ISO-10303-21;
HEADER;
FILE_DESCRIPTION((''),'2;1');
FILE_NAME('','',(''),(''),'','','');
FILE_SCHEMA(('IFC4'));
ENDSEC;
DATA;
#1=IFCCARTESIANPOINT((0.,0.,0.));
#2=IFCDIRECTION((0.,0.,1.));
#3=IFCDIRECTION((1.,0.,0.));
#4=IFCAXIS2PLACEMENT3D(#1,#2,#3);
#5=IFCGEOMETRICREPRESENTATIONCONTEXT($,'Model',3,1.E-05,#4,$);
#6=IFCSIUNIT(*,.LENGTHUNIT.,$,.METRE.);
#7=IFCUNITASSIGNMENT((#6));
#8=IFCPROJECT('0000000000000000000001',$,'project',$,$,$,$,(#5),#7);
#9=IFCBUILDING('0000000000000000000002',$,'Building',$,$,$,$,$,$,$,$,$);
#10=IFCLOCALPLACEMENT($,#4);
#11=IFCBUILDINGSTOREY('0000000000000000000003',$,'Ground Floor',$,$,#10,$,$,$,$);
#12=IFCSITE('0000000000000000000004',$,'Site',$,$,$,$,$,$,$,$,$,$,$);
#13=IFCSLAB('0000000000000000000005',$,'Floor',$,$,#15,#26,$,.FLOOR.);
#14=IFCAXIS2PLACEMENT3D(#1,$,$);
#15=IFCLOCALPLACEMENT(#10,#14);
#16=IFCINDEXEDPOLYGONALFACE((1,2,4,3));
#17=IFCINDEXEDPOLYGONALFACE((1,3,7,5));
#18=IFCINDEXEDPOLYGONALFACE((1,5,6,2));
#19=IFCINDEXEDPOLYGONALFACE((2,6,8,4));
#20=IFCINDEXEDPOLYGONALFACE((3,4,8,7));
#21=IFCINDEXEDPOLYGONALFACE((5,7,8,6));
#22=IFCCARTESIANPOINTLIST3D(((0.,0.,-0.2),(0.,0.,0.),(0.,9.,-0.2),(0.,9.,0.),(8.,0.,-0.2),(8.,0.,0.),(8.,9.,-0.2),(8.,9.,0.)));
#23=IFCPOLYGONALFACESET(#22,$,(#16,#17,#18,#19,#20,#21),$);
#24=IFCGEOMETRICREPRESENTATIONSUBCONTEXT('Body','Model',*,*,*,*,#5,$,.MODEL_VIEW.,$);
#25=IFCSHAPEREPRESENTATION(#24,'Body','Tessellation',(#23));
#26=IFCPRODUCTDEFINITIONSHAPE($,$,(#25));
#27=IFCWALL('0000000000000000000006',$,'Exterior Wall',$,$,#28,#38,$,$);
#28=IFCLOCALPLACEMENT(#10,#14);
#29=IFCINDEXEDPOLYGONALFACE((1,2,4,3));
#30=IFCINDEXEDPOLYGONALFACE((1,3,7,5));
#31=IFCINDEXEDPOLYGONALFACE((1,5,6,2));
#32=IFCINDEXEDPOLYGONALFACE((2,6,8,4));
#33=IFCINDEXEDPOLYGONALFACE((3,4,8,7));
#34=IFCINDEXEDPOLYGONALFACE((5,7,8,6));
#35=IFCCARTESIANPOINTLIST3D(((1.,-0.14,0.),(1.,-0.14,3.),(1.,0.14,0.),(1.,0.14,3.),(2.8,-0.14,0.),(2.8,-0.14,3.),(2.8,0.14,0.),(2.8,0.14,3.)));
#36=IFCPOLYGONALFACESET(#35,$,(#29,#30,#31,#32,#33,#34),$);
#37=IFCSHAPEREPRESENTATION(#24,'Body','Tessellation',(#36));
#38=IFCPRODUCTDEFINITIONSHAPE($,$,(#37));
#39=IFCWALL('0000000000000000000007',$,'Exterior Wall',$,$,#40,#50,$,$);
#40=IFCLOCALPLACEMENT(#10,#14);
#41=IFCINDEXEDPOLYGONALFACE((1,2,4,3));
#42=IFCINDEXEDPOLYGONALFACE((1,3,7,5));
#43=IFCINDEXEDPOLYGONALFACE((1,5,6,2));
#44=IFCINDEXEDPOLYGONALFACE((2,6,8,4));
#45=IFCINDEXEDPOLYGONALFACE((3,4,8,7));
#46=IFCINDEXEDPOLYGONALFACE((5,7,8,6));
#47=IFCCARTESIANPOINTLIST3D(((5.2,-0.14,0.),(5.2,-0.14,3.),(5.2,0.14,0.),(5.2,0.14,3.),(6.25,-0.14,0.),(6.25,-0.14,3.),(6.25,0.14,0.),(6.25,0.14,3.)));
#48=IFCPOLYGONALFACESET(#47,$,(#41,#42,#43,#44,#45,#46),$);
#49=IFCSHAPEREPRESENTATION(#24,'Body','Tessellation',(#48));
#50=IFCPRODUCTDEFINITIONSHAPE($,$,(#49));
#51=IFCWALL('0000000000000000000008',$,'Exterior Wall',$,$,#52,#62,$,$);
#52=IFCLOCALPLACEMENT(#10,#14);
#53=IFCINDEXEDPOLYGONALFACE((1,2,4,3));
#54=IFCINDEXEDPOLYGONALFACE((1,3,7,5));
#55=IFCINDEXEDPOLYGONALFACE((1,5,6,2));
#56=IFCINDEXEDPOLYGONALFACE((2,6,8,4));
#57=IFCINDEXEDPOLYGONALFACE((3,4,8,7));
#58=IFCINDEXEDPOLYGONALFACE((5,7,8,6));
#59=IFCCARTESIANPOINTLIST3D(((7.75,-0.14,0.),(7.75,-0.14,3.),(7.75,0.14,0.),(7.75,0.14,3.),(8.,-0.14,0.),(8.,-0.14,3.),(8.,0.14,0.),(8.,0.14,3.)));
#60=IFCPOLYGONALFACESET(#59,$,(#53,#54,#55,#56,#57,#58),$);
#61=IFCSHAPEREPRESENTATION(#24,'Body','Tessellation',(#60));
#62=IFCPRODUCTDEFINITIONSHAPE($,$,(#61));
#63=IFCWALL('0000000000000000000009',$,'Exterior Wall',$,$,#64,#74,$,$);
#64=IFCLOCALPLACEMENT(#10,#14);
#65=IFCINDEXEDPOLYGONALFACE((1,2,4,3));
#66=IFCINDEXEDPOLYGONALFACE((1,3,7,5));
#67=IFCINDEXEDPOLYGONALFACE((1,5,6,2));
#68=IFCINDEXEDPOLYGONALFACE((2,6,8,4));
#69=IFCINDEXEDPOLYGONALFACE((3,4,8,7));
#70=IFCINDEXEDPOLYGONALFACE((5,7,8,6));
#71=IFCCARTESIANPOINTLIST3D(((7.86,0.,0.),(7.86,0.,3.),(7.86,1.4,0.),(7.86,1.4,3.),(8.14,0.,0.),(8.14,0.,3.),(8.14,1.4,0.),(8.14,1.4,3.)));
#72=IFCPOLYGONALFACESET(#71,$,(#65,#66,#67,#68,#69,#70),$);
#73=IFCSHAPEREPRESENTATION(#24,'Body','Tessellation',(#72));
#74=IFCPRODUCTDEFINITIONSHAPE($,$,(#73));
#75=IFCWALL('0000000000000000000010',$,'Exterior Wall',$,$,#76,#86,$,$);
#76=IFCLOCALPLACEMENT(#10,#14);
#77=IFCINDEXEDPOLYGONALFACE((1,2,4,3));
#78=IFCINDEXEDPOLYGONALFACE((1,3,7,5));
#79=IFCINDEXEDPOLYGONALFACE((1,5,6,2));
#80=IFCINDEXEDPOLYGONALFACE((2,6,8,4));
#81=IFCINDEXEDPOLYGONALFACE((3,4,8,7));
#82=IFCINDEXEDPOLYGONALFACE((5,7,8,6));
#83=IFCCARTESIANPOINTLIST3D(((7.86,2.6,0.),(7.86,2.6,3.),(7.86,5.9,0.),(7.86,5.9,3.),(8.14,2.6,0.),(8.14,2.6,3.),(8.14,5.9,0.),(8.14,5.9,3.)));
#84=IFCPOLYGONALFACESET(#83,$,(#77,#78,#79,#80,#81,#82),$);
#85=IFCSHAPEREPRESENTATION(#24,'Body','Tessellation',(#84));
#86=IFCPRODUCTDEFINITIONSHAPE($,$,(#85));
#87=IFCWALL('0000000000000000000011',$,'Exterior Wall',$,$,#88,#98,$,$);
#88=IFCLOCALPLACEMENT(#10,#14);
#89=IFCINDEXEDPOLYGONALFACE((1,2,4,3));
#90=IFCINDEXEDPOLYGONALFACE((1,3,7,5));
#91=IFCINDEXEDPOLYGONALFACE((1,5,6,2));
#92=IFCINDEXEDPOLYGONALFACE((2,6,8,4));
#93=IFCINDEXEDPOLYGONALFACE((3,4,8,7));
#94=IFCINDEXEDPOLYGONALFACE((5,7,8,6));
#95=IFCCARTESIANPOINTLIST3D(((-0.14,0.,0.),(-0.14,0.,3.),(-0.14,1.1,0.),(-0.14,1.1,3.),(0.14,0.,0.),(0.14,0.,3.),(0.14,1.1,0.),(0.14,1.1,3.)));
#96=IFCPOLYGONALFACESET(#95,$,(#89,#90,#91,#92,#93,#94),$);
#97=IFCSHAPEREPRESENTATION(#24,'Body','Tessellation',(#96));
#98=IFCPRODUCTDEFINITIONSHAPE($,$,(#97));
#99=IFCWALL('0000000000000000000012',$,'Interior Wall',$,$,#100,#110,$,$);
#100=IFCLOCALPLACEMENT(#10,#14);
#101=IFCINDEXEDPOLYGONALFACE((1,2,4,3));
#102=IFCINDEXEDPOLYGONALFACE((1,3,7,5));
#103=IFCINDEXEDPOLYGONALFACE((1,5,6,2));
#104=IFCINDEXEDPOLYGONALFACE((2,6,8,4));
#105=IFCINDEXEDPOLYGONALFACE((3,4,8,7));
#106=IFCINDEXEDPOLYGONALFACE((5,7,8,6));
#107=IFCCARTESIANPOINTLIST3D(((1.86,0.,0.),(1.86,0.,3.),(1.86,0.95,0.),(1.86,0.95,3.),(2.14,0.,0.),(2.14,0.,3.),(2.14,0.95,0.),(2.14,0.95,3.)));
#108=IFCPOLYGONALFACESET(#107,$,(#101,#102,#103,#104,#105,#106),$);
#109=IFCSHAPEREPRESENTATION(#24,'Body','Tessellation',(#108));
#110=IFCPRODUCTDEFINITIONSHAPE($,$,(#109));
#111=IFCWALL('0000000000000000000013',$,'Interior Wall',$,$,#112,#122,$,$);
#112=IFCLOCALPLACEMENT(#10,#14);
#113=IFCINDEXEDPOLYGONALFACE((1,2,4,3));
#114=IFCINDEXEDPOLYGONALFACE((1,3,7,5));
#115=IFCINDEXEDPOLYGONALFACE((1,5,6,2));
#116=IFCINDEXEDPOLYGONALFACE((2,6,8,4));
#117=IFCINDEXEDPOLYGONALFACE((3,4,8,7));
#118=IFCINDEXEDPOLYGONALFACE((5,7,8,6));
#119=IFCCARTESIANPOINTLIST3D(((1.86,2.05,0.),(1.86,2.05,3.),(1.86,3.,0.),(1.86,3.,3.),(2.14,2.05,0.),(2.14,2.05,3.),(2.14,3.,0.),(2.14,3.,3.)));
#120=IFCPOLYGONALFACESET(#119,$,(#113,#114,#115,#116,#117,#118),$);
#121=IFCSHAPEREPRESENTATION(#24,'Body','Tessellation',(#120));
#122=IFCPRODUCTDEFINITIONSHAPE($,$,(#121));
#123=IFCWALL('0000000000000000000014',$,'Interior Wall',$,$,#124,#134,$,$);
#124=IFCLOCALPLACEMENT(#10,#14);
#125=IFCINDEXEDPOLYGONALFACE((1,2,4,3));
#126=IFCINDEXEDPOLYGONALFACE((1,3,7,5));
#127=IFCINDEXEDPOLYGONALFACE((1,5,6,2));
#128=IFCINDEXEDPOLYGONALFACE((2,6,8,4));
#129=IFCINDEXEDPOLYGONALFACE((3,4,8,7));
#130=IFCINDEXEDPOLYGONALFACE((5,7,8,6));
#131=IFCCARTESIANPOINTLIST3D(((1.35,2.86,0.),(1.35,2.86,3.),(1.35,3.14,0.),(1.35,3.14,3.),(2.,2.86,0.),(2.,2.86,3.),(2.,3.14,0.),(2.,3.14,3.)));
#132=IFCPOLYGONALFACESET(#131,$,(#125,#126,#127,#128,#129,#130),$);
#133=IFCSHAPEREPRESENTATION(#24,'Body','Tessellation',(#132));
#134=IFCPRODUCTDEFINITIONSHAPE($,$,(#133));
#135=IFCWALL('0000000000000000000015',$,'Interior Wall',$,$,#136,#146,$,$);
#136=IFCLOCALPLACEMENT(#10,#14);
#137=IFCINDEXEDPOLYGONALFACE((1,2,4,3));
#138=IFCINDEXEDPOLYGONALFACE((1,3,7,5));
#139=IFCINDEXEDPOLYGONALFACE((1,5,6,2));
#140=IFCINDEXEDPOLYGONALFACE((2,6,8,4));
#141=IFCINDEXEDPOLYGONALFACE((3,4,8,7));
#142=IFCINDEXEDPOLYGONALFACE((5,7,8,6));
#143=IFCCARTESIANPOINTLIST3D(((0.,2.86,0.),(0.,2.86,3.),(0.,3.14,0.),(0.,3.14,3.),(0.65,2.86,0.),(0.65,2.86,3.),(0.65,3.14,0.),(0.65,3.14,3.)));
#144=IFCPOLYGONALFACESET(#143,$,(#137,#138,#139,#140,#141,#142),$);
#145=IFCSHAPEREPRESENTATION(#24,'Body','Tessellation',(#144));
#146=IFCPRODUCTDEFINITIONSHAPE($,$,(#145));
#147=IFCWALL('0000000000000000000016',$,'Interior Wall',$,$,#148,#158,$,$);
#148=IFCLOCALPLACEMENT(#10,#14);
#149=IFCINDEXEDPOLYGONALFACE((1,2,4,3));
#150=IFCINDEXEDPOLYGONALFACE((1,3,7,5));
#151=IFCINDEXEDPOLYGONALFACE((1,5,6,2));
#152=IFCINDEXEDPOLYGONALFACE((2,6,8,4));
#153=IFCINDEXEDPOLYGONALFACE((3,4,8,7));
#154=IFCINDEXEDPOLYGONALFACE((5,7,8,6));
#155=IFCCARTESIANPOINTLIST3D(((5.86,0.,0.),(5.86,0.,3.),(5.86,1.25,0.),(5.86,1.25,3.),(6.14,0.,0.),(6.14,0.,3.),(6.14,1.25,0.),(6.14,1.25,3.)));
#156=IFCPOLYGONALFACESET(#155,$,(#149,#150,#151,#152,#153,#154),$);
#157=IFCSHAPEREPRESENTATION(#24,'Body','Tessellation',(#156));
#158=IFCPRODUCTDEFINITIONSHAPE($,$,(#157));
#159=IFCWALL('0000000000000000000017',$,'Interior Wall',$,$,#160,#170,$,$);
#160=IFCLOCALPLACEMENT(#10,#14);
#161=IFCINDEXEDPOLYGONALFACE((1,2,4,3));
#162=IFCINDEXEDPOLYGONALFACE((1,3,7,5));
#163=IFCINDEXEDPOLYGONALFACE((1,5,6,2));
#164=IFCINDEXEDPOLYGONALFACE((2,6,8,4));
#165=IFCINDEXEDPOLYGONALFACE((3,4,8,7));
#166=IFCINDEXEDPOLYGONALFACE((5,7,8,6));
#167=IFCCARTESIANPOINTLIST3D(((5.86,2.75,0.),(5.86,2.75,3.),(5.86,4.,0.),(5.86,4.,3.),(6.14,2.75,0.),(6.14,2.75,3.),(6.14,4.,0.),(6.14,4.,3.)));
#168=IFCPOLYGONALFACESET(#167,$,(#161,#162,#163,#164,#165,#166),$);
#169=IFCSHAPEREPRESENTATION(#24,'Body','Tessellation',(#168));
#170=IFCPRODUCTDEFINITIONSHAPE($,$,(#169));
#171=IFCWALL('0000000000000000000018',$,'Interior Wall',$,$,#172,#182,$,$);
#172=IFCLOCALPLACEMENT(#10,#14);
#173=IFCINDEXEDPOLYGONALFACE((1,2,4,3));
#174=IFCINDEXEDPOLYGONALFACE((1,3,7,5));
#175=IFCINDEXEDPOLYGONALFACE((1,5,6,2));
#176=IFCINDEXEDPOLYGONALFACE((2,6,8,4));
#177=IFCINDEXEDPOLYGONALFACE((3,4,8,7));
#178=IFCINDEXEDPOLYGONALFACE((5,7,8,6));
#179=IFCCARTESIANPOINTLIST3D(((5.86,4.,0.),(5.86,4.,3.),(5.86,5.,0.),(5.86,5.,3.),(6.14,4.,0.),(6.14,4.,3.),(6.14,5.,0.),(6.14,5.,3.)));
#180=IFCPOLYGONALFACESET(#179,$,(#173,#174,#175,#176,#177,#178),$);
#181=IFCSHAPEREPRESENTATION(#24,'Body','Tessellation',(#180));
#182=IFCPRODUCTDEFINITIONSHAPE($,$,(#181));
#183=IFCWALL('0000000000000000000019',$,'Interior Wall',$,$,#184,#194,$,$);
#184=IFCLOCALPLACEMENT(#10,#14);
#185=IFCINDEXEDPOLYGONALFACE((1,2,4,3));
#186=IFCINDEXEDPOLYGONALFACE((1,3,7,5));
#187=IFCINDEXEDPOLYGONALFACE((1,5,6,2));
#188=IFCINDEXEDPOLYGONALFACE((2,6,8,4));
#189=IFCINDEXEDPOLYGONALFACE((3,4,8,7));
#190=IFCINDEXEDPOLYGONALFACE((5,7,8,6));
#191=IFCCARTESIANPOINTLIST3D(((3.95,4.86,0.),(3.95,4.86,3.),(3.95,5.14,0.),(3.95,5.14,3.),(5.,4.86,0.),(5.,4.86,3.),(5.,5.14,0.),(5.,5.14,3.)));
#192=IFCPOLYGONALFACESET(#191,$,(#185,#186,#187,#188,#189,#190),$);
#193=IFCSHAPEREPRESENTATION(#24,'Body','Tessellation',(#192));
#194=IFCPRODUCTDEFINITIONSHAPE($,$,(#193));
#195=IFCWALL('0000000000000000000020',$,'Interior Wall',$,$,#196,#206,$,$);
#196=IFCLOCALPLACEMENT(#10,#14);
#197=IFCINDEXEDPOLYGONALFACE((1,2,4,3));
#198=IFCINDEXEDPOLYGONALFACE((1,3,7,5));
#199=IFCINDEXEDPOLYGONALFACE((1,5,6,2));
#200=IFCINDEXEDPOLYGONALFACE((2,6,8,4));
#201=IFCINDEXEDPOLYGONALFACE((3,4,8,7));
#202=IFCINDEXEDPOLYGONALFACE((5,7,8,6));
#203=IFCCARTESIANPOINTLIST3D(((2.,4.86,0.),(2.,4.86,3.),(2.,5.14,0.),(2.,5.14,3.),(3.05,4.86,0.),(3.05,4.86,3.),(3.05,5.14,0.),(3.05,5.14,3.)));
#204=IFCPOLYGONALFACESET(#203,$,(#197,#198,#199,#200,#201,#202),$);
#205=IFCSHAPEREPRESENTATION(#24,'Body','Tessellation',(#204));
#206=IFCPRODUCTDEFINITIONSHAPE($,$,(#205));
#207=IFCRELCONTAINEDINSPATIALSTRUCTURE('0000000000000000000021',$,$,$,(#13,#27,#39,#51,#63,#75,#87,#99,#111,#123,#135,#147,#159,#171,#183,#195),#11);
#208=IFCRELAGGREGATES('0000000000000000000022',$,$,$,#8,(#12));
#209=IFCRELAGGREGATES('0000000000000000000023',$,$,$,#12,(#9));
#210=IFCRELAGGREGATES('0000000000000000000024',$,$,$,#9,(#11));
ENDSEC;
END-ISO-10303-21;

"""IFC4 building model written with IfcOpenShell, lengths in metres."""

from ifc_helpers import new_model, si_unit, frame, origin_with_axes, place, context, subcontext, project, spatial, indexed_curve, outline, extrude, element, save


model = new_model("IFC4")

# Units and contexts
model_context = context("Model", 3, precision=1e-05, world=origin_with_axes())
body_context = subcontext(model_context, "Body", "Model", "MODEL_VIEW")
ifc_project = project(units=[si_unit("LENGTHUNIT", "METRE")], contexts=[model_context])

# Site, building, storey
site = spatial("IfcSite", under=ifc_project, Name="Site")
building = spatial("IfcBuilding", under=site, Name="Building")
storey_placement = place(None, origin_with_axes())
storey = spatial("IfcBuildingStorey", under=building, at=storey_placement, Name="Ground Floor")

# Slab
slab_placement = place(storey_placement, frame((0.0, 0.0, -0.2), z_axis=(0.0, 0.0, 1.0), x_axis=(1.0, 0.0, 0.0)))
element("IfcSlab", 1, at=slab_placement, inside=storey, Name="Floor", PredefinedType="FLOOR", context=body_context, shape_type="SweptSolid", body=[
    extrude(outline(indexed_curve([(0.0, 0.0), (8.0, 0.0), (8.0, 9.0), (0.0, 9.0)])), None, (0.0, 0.0, 1.0), 0.2),
])

# Walls
wall_1_placement = place(storey_placement, frame((1.0, 0.0, 0.0), z_axis=(0.0, 0.0, 1.0), x_axis=(1.0, 0.0, 0.0)))
element("IfcWall", 2, at=wall_1_placement, inside=storey, Name="Exterior Wall", context=body_context, shape_type="SweptSolid", body=[
    extrude(outline(indexed_curve([(0.0, 0.0), (0.0, 0.28), (1.8, 0.28), (1.8, 0.0), (0.0, 0.0)], self_intersect=False)), frame((0.0, -0.14, 0.0), z_axis=(0.0, 0.0, 1.0), x_axis=(1.0, 0.0, 0.0)), (0.0, 0.0, 1.0), 3.0),
])
wall_2_placement = place(storey_placement, frame((5.2, 0.0, 0.0), z_axis=(0.0, 0.0, 1.0), x_axis=(1.0, 0.0, 0.0)))
element("IfcWall", 3, at=wall_2_placement, inside=storey, Name="Exterior Wall", context=body_context, shape_type="SweptSolid", body=[
    extrude(outline(indexed_curve([(0.0, 0.0), (0.0, 0.28), (1.05, 0.28), (1.05, 0.0), (0.0, 0.0)], self_intersect=False)), frame((0.0, -0.14, 0.0), z_axis=(0.0, 0.0, 1.0), x_axis=(1.0, 0.0, 0.0)), (0.0, 0.0, 1.0), 3.0),
])
wall_3_placement = place(storey_placement, frame((7.75, 0.0, 0.0), z_axis=(0.0, 0.0, 1.0), x_axis=(1.0, 0.0, 0.0)))
element("IfcWall", 4, at=wall_3_placement, inside=storey, Name="Exterior Wall", context=body_context, shape_type="SweptSolid", body=[
    extrude(outline(indexed_curve([(0.0, 0.0), (0.0, 0.28), (0.25, 0.28), (0.25, 0.0), (0.0, 0.0)], self_intersect=False)), frame((0.0, -0.14, 0.0), z_axis=(0.0, 0.0, 1.0), x_axis=(1.0, 0.0, 0.0)), (0.0, 0.0, 1.0), 3.0),
])
wall_4_placement = place(storey_placement, frame((8.0, 0.0, 0.0), z_axis=(0.0, 0.0, 1.0), x_axis=(0.0, 1.0, 0.0)))
element("IfcWall", 5, at=wall_4_placement, inside=storey, Name="Exterior Wall", context=body_context, shape_type="SweptSolid", body=[
    extrude(outline(indexed_curve([(0.0, 0.0), (0.0, 0.28), (1.4, 0.28), (1.4, 0.0), (0.0, 0.0)], self_intersect=False)), frame((0.0, -0.14, 0.0), z_axis=(0.0, 0.0, 1.0), x_axis=(1.0, 0.0, 0.0)), (0.0, 0.0, 1.0), 3.0),
])
wall_5_placement = place(storey_placement, frame((8.0, 2.6, 0.0), z_axis=(0.0, 0.0, 1.0), x_axis=(0.0, 1.0, 0.0)))
element("IfcWall", 6, at=wall_5_placement, inside=storey, Name="Exterior Wall", context=body_context, shape_type="SweptSolid", body=[
    extrude(outline(indexed_curve([(0.0, 0.0), (0.0, 0.28), (3.3, 0.28), (3.3, 0.0), (0.0, 0.0)], self_intersect=False)), frame((0.0, -0.14, 0.0), z_axis=(0.0, 0.0, 1.0), x_axis=(1.0, 0.0, 0.0)), (0.0, 0.0, 1.0), 3.0),
])
wall_6_placement = place(storey_placement, frame((0.0, 1.1, 0.0), z_axis=(0.0, 0.0, 1.0), x_axis=(0.0, -1.0, 0.0)))
element("IfcWall", 7, at=wall_6_placement, inside=storey, Name="Exterior Wall", context=body_context, shape_type="SweptSolid", body=[
    extrude(outline(indexed_curve([(0.0, 0.0), (0.0, 0.28), (1.1, 0.28), (1.1, 0.0), (0.0, 0.0)], self_intersect=False)), frame((0.0, -0.14, 0.0), z_axis=(0.0, 0.0, 1.0), x_axis=(1.0, 0.0, 0.0)), (0.0, 0.0, 1.0), 3.0),
])
wall_7_placement = place(storey_placement, frame((2.0, 0.0, 0.0), z_axis=(0.0, 0.0, 1.0), x_axis=(0.0, 1.0, 0.0)))
element("IfcWall", 8, at=wall_7_placement, inside=storey, Name="Interior Wall", context=body_context, shape_type="SweptSolid", body=[
    extrude(outline(indexed_curve([(0.0, 0.0), (0.0, 0.28), (0.95, 0.28), (0.95, 0.0), (0.0, 0.0)], self_intersect=False)), frame((0.0, -0.14, 0.0), z_axis=(0.0, 0.0, 1.0), x_axis=(1.0, 0.0, 0.0)), (0.0, 0.0, 1.0), 3.0),
])
wall_8_placement = place(storey_placement, frame((2.0, 2.05, 0.0), z_axis=(0.0, 0.0, 1.0), x_axis=(0.0, 1.0, 0.0)))
element("IfcWall", 9, at=wall_8_placement, inside=storey, Name="Interior Wall", context=body_context, shape_type="SweptSolid", body=[
    extrude(outline(indexed_curve([(0.0, 0.0), (0.0, 0.28), (0.95, 0.28), (0.95, 0.0), (0.0, 0.0)], self_intersect=False)), frame((0.0, -0.14, 0.0), z_axis=(0.0, 0.0, 1.0), x_axis=(1.0, 0.0, 0.0)), (0.0, 0.0, 1.0), 3.0),
])
for number, where, z_axis, x_axis, name in (
    (10, (2.0, 3.0, 0.0), (0.0, 0.0, 1.0), (-1.0, 0.0, 0.0), "Interior Wall"),
    (11, (0.65, 3.0, 0.0), (0.0, 0.0, 1.0), (-1.0, 0.0, 0.0), "Interior Wall"),
):
    element("IfcWall", number, at=place(storey_placement, frame(where, z_axis=z_axis, x_axis=x_axis)), inside=storey, Name=name, context=body_context, shape_type="SweptSolid", body=[
        extrude(outline(indexed_curve([(0.0, 0.0), (0.0, 0.28), (0.65, 0.28), (0.65, 0.0), (0.0, 0.0)], self_intersect=False)), frame((0.0, -0.14, 0.0), z_axis=(0.0, 0.0, 1.0), x_axis=(1.0, 0.0, 0.0)), (0.0, 0.0, 1.0), 3.0),
    ])
for number, where, z_axis, x_axis, name in (
    (12, (6.0, 0.0, 0.0), (0.0, 0.0, 1.0), (0.0, 1.0, 0.0), "Interior Wall"),
    (13, (6.0, 2.75, 0.0), (0.0, 0.0, 1.0), (0.0, 1.0, 0.0), "Interior Wall"),
):
    element("IfcWall", number, at=place(storey_placement, frame(where, z_axis=z_axis, x_axis=x_axis)), inside=storey, Name=name, context=body_context, shape_type="SweptSolid", body=[
        extrude(outline(indexed_curve([(0.0, 0.0), (0.0, 0.28), (1.25, 0.28), (1.25, 0.0), (0.0, 0.0)], self_intersect=False)), frame((0.0, -0.14, 0.0), z_axis=(0.0, 0.0, 1.0), x_axis=(1.0, 0.0, 0.0)), (0.0, 0.0, 1.0), 3.0),
    ])
wall_9_placement = place(storey_placement, frame((6.0, 4.0, 0.0), z_axis=(0.0, 0.0, 1.0), x_axis=(0.0, 1.0, 0.0)))
element("IfcWall", 14, at=wall_9_placement, inside=storey, Name="Interior Wall", context=body_context, shape_type="SweptSolid", body=[
    extrude(outline(indexed_curve([(0.0, 0.0), (0.0, 0.28), (1.0, 0.28), (1.0, 0.0), (0.0, 0.0)], self_intersect=False)), frame((0.0, -0.14, 0.0), z_axis=(0.0, 0.0, 1.0), x_axis=(1.0, 0.0, 0.0)), (0.0, 0.0, 1.0), 3.0),
])
for number, where, z_axis, x_axis, name in (
    (15, (5.0, 5.0, 0.0), (0.0, 0.0, 1.0), (-1.0, 0.0, 0.0), "Interior Wall"),
    (16, (3.05, 5.0, 0.0), (0.0, 0.0, 1.0), (-1.0, 0.0, 0.0), "Interior Wall"),
):
    element("IfcWall", number, at=place(storey_placement, frame(where, z_axis=z_axis, x_axis=x_axis)), inside=storey, Name=name, context=body_context, shape_type="SweptSolid", body=[
        extrude(outline(indexed_curve([(0.0, 0.0), (0.0, 0.28), (1.05, 0.28), (1.05, 0.0), (0.0, 0.0)], self_intersect=False)), frame((0.0, -0.14, 0.0), z_axis=(0.0, 0.0, 1.0), x_axis=(1.0, 0.0, 0.0)), (0.0, 0.0, 1.0), 3.0),
    ])

save(model, "model.ifc")
